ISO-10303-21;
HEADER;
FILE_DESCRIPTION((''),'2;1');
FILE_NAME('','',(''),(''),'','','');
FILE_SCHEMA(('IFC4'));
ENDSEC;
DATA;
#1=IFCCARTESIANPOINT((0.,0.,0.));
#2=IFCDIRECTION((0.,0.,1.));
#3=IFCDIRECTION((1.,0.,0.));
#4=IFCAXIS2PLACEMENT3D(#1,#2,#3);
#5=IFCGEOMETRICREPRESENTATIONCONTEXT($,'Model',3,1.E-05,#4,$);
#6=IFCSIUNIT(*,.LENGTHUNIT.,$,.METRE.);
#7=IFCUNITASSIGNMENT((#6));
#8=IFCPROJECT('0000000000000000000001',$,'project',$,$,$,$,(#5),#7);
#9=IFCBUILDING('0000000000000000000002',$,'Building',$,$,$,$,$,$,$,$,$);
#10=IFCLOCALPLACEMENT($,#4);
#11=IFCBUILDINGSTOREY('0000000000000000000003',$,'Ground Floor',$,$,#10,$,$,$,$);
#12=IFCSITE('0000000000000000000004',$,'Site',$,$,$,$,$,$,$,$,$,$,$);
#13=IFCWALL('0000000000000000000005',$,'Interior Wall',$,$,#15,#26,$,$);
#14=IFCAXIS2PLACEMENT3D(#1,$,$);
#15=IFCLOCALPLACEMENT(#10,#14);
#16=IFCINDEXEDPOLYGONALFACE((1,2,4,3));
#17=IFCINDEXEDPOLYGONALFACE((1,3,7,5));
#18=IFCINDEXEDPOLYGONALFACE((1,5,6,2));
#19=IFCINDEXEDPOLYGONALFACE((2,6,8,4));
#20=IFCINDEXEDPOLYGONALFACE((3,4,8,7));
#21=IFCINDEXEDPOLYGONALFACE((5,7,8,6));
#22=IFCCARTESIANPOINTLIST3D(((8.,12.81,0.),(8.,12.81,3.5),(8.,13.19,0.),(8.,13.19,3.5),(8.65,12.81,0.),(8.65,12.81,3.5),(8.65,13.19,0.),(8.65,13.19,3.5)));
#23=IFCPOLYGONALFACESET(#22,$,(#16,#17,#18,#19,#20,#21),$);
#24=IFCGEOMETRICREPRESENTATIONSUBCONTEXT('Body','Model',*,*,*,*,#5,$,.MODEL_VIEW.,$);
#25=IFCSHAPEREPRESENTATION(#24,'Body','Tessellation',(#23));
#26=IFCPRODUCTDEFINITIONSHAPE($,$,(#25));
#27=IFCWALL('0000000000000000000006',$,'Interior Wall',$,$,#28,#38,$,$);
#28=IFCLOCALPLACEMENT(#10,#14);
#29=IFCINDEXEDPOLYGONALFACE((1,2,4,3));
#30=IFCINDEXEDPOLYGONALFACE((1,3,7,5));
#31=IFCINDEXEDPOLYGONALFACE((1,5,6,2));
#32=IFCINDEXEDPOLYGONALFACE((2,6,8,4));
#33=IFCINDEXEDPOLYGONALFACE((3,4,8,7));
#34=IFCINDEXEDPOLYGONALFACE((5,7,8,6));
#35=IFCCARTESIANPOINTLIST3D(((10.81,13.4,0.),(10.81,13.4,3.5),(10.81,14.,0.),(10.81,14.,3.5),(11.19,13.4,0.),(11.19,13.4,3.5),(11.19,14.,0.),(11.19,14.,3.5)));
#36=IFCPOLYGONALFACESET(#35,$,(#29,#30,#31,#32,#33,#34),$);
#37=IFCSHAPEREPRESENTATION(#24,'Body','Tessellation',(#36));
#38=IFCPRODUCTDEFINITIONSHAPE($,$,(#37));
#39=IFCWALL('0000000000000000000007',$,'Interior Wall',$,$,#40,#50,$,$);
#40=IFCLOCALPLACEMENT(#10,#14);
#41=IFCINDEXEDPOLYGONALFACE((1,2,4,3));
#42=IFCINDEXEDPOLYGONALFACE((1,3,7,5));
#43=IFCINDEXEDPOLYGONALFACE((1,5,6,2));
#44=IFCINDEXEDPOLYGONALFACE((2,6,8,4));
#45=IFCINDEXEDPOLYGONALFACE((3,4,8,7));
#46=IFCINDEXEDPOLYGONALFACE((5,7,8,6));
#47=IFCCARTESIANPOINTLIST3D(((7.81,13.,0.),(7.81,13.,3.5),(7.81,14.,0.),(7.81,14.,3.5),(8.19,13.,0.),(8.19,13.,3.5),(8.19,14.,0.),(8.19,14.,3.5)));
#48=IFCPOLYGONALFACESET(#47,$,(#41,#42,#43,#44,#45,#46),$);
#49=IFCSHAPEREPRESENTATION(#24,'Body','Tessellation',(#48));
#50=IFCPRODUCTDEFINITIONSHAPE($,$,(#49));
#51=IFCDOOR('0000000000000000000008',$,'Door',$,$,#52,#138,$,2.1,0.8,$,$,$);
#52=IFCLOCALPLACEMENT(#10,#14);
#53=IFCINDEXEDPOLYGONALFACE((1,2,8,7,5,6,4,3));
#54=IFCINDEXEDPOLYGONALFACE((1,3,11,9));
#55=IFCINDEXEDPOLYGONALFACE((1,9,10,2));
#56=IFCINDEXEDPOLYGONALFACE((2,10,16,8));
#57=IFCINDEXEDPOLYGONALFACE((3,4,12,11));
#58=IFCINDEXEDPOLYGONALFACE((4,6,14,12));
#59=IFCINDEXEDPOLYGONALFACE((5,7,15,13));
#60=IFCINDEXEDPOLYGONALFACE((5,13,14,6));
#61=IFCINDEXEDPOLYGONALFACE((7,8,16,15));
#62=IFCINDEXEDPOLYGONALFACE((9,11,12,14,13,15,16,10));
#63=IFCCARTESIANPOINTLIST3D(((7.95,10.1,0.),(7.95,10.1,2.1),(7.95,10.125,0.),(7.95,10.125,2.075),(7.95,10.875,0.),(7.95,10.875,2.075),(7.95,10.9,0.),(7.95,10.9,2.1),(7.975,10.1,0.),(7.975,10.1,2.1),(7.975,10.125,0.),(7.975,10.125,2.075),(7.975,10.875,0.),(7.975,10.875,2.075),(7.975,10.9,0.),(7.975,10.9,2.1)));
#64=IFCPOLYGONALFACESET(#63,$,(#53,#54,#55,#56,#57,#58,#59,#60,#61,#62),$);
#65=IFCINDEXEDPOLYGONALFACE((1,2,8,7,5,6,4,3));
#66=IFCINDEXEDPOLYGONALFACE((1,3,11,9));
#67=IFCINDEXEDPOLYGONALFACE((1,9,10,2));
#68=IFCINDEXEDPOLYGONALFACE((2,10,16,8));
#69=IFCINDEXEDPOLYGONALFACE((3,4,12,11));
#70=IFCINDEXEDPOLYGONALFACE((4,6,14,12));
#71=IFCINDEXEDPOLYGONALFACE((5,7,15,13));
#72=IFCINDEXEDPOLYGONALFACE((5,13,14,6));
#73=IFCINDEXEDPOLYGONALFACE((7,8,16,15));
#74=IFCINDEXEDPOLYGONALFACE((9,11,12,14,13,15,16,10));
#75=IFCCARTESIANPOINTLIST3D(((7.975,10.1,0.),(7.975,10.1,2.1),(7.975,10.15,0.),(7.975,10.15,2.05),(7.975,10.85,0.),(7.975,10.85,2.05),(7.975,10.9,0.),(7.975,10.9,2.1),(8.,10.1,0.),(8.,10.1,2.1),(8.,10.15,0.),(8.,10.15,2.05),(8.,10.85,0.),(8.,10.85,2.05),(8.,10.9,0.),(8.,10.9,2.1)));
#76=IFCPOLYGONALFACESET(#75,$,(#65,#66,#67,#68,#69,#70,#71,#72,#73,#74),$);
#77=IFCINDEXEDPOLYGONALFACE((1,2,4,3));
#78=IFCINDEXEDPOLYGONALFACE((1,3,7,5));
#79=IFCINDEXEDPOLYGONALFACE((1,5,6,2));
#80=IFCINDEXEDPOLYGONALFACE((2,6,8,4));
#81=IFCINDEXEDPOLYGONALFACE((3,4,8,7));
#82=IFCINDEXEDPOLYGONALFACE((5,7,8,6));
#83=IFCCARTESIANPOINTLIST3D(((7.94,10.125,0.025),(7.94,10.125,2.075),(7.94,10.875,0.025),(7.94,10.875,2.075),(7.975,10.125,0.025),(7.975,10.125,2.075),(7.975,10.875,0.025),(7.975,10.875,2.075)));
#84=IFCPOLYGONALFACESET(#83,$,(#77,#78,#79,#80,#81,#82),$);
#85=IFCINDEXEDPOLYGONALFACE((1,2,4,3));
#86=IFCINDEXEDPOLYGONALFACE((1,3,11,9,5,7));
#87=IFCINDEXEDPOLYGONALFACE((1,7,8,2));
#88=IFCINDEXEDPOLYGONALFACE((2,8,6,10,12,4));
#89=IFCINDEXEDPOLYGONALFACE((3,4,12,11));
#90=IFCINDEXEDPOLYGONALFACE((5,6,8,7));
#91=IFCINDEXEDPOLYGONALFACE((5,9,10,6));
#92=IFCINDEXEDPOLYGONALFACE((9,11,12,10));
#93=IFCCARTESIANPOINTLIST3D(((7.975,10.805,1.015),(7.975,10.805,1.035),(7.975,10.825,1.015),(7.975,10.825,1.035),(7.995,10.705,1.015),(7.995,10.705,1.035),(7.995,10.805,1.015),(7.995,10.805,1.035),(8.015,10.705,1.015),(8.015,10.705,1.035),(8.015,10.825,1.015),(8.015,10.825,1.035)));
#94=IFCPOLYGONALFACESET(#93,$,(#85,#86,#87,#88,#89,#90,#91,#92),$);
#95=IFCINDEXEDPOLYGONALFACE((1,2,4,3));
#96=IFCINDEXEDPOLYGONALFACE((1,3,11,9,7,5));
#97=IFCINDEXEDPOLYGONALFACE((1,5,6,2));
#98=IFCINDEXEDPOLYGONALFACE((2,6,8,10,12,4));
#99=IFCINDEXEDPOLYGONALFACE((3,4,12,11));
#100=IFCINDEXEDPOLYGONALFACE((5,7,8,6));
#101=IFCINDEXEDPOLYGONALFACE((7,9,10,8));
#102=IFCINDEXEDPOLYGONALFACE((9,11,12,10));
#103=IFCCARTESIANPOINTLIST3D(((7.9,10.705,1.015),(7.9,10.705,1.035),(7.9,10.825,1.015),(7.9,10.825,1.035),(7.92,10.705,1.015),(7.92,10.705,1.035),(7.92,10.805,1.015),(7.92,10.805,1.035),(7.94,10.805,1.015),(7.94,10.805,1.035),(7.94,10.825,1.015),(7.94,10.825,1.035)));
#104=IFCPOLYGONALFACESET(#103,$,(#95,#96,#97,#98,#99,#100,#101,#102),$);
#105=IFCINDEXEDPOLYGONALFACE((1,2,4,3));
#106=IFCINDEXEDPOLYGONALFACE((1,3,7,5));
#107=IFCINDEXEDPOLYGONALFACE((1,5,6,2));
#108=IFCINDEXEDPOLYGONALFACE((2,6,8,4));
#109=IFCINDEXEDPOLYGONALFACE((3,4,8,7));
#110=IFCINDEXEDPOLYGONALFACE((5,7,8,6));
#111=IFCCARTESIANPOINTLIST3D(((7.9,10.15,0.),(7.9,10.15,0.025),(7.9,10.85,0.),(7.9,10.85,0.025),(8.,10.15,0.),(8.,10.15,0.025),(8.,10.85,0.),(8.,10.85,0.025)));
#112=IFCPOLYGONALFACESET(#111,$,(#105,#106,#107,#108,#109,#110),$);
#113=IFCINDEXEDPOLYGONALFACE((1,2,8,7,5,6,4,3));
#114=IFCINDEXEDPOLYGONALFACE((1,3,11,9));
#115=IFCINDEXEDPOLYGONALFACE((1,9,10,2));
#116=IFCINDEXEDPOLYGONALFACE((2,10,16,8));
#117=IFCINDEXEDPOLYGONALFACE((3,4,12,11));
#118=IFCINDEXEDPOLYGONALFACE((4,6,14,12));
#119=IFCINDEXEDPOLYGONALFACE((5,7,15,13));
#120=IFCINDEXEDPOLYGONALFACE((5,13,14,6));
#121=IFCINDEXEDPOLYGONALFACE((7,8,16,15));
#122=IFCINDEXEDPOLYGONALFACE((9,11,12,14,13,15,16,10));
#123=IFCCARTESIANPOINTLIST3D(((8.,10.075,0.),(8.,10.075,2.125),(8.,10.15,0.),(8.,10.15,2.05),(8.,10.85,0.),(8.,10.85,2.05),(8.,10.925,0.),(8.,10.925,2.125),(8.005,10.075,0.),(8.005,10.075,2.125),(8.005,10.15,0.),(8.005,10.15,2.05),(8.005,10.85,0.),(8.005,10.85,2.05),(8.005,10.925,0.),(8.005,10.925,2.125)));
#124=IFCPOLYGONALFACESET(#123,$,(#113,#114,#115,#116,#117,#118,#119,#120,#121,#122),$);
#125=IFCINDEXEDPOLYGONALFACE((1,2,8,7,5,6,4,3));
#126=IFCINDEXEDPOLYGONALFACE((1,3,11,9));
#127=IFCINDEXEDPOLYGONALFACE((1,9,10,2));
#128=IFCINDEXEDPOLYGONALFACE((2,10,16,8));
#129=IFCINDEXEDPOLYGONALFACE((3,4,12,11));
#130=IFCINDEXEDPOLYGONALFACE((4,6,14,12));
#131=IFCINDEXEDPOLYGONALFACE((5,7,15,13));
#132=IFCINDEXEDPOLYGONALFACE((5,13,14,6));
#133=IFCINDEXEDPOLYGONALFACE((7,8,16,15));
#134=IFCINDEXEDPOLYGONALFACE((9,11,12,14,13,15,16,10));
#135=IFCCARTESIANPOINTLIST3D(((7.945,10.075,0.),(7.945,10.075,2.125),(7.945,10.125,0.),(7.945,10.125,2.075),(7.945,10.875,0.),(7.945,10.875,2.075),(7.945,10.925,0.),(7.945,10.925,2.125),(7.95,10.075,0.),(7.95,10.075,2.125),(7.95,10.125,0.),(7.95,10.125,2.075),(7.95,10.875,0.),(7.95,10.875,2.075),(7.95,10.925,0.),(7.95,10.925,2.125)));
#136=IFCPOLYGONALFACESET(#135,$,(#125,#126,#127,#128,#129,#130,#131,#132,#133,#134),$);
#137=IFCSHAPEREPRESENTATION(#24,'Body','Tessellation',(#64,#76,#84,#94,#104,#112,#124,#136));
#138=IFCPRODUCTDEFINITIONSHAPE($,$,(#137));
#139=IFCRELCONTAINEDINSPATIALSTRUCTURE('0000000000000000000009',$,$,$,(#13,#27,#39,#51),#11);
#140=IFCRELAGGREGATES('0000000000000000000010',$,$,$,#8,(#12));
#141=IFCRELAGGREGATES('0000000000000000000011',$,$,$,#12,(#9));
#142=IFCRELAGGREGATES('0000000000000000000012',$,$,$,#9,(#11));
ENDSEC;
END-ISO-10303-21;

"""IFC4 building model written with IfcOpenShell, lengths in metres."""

from ifc_helpers import new_model, si_unit, frame, origin_with_axes, place, context, subcontext, project, spatial, line, indexed_curve, outline, extrude, element, save


model = new_model("IFC4")

# Units and contexts
model_context = context("Model", 3, precision=1e-05, world=origin_with_axes())
body_context = subcontext(model_context, "Body", "Model", "MODEL_VIEW")
ifc_project = project(units=[si_unit("LENGTHUNIT", "METRE")], contexts=[model_context])

# Site, building, storey
site = spatial("IfcSite", under=ifc_project, Name="Site")
building = spatial("IfcBuilding", under=site, Name="Building")
storey_placement = place(None, origin_with_axes())
storey = spatial("IfcBuildingStorey", under=building, at=storey_placement, Name="Ground Floor")

# Walls
wall_1_placement = place(storey_placement, frame((8.65, 13.0, 0.0), z_axis=(0.0, 0.0, 1.0), x_axis=(-1.0, 0.0, 0.0)))
element("IfcWall", 1, at=wall_1_placement, inside=storey, Name="Interior Wall", context=body_context, shape_type="SweptSolid", body=[
    extrude(outline(indexed_curve([(0.0, 0.0), (0.0, 0.38), (0.65, 0.38), (0.65, 0.0), (0.0, 0.0)], self_intersect=False)), frame((0.0, -0.19, 0.0), z_axis=(0.0, 0.0, 1.0), x_axis=(1.0, 0.0, 0.0)), (0.0, 0.0, 1.0), 3.5),
])
wall_2_placement = place(storey_placement, frame((11.0, 13.4, 0.0), z_axis=(0.0, 0.0, 1.0), x_axis=(0.0, 1.0, 0.0)))
element("IfcWall", 2, at=wall_2_placement, inside=storey, Name="Interior Wall", context=body_context, shape_type="SweptSolid", body=[
    extrude(outline(indexed_curve([(0.0, 0.0), (0.0, 0.38), (0.6, 0.38), (0.6, 0.0), (0.0, 0.0)], self_intersect=False)), frame((0.0, -0.19, 0.0), z_axis=(0.0, 0.0, 1.0), x_axis=(1.0, 0.0, 0.0)), (0.0, 0.0, 1.0), 3.5),
])
wall_3_placement = place(storey_placement, frame((8.0, 14.0, 0.0), z_axis=(0.0, 0.0, 1.0), x_axis=(0.0, -1.0, 0.0)))
element("IfcWall", 3, at=wall_3_placement, inside=storey, Name="Interior Wall", context=body_context, shape_type="SweptSolid", body=[
    extrude(outline(indexed_curve([(0.0, 0.0), (0.0, 0.38), (1.0, 0.38), (1.0, 0.0), (0.0, 0.0)], self_intersect=False)), frame((0.0, -0.19, 0.0), z_axis=(0.0, 0.0, 1.0), x_axis=(1.0, 0.0, 0.0)), (0.0, 0.0, 1.0), 3.5),
])

# Door
door_1_placement = place(storey_placement, frame((8.0, 10.1, 0.0), z_axis=(0.0, 0.0, 1.0), x_axis=(0.0, 1.0, 0.0)))
element("IfcDoor", 4, at=door_1_placement, inside=storey, Name="Door", OverallHeight=2.1, OverallWidth=0.8, context=body_context, shape_type="SweptSolid", body=[
    extrude(outline(indexed_curve([(0.0, 0.0), (0.0, 2.1), (0.8, 2.1), (0.8, 0.0), (0.775, 0.0), (0.775, 2.075), (0.025, 2.075), (0.025, 0.0)], segments=[line(1, 2, 3, 4, 5, 6, 7, 8, 1)])), frame((0.0, 0.025, 0.0), z_axis=(0.0, -1.0, 0.0), x_axis=(1.0, 0.0, 0.0)), (0.0, 0.0, -1.0), 0.025),
    extrude(outline(indexed_curve([(0.0, 0.0), (0.0, 2.1), (0.8, 2.1), (0.8, 0.0), (0.75, 0.0), (0.75, 2.05), (0.05, 2.05), (0.05, 0.0)], segments=[line(1, 2, 3, 4, 5, 6, 7, 8, 1)])), frame((0.0, 0.0, 0.0), z_axis=(0.0, -1.0, 0.0), x_axis=(1.0, 0.0, 0.0)), (0.0, 0.0, -1.0), 0.025),
    extrude(outline(indexed_curve([(0.0, 0.0), (0.75, 0.0), (0.75, 0.035), (0.0, 0.035)], segments=[line(1, 2, 3, 4, 1)])), frame((0.025, 0.025, 0.025), z_axis=(0.0, 0.0, 1.0), x_axis=(1.0, 0.0, 0.0)), (0.0, 0.0, 1.0), 2.05),
    extrude(outline(indexed_curve([(0.0, 0.0), (0.0, -0.04), (-0.12, -0.04), (-0.12, -0.02), (-0.02, -0.02), (-0.02, 0.0)], segments=[line(1, 2, 3, 4, 5, 6, 1)])), frame((0.725, 0.025, 1.015), z_axis=(0.0, 0.0, 1.0), x_axis=(1.0, 0.0, 0.0)), (0.0, 0.0, 1.0), 0.02),
    extrude(outline(indexed_curve([(0.0, 0.0), (0.0, 0.04), (-0.12, 0.04), (-0.12, 0.02), (-0.02, 0.02), (-0.02, 0.0)], segments=[line(1, 2, 3, 4, 5, 6, 1)])), frame((0.725, 0.06, 1.015), z_axis=(0.0, 0.0, 1.0), x_axis=(1.0, 0.0, 0.0)), (0.0, 0.0, 1.0), 0.02),
    extrude(outline(indexed_curve([(0.0, 0.0), (0.7, 0.0), (0.7, 0.1), (0.0, 0.1)], segments=[line(1, 2, 3, 4, 1)])), frame((0.05, 0.0, 0.0), z_axis=(0.0, 0.0, 1.0), x_axis=(1.0, 0.0, 0.0)), (0.0, 0.0, 1.0), 0.025),
    extrude(outline(indexed_curve([(0.0, 0.0), (0.0, 2.125), (0.85, 2.125), (0.85, 0.0), (0.775, 0.0), (0.775, 2.05), (0.075, 2.05), (0.075, 0.0)], segments=[line(1, 2, 3, 4, 5, 6, 7, 8, 1)])), frame((-0.025, -0.005, 0.0), z_axis=(0.0, -1.0, 0.0), x_axis=(1.0, 0.0, 0.0)), (0.0, 0.0, -1.0), 0.005),
    extrude(outline(indexed_curve([(0.0, 0.0), (0.0, 2.125), (0.85, 2.125), (0.85, 0.0), (0.8, 0.0), (0.8, 2.075), (0.05, 2.075), (0.05, 0.0)], segments=[line(1, 2, 3, 4, 5, 6, 7, 8, 1)])), frame((-0.025, 0.05, 0.0), z_axis=(0.0, -1.0, 0.0), x_axis=(1.0, 0.0, 0.0)), (0.0, 0.0, -1.0), 0.005),
])

save(model, "model.ifc")
